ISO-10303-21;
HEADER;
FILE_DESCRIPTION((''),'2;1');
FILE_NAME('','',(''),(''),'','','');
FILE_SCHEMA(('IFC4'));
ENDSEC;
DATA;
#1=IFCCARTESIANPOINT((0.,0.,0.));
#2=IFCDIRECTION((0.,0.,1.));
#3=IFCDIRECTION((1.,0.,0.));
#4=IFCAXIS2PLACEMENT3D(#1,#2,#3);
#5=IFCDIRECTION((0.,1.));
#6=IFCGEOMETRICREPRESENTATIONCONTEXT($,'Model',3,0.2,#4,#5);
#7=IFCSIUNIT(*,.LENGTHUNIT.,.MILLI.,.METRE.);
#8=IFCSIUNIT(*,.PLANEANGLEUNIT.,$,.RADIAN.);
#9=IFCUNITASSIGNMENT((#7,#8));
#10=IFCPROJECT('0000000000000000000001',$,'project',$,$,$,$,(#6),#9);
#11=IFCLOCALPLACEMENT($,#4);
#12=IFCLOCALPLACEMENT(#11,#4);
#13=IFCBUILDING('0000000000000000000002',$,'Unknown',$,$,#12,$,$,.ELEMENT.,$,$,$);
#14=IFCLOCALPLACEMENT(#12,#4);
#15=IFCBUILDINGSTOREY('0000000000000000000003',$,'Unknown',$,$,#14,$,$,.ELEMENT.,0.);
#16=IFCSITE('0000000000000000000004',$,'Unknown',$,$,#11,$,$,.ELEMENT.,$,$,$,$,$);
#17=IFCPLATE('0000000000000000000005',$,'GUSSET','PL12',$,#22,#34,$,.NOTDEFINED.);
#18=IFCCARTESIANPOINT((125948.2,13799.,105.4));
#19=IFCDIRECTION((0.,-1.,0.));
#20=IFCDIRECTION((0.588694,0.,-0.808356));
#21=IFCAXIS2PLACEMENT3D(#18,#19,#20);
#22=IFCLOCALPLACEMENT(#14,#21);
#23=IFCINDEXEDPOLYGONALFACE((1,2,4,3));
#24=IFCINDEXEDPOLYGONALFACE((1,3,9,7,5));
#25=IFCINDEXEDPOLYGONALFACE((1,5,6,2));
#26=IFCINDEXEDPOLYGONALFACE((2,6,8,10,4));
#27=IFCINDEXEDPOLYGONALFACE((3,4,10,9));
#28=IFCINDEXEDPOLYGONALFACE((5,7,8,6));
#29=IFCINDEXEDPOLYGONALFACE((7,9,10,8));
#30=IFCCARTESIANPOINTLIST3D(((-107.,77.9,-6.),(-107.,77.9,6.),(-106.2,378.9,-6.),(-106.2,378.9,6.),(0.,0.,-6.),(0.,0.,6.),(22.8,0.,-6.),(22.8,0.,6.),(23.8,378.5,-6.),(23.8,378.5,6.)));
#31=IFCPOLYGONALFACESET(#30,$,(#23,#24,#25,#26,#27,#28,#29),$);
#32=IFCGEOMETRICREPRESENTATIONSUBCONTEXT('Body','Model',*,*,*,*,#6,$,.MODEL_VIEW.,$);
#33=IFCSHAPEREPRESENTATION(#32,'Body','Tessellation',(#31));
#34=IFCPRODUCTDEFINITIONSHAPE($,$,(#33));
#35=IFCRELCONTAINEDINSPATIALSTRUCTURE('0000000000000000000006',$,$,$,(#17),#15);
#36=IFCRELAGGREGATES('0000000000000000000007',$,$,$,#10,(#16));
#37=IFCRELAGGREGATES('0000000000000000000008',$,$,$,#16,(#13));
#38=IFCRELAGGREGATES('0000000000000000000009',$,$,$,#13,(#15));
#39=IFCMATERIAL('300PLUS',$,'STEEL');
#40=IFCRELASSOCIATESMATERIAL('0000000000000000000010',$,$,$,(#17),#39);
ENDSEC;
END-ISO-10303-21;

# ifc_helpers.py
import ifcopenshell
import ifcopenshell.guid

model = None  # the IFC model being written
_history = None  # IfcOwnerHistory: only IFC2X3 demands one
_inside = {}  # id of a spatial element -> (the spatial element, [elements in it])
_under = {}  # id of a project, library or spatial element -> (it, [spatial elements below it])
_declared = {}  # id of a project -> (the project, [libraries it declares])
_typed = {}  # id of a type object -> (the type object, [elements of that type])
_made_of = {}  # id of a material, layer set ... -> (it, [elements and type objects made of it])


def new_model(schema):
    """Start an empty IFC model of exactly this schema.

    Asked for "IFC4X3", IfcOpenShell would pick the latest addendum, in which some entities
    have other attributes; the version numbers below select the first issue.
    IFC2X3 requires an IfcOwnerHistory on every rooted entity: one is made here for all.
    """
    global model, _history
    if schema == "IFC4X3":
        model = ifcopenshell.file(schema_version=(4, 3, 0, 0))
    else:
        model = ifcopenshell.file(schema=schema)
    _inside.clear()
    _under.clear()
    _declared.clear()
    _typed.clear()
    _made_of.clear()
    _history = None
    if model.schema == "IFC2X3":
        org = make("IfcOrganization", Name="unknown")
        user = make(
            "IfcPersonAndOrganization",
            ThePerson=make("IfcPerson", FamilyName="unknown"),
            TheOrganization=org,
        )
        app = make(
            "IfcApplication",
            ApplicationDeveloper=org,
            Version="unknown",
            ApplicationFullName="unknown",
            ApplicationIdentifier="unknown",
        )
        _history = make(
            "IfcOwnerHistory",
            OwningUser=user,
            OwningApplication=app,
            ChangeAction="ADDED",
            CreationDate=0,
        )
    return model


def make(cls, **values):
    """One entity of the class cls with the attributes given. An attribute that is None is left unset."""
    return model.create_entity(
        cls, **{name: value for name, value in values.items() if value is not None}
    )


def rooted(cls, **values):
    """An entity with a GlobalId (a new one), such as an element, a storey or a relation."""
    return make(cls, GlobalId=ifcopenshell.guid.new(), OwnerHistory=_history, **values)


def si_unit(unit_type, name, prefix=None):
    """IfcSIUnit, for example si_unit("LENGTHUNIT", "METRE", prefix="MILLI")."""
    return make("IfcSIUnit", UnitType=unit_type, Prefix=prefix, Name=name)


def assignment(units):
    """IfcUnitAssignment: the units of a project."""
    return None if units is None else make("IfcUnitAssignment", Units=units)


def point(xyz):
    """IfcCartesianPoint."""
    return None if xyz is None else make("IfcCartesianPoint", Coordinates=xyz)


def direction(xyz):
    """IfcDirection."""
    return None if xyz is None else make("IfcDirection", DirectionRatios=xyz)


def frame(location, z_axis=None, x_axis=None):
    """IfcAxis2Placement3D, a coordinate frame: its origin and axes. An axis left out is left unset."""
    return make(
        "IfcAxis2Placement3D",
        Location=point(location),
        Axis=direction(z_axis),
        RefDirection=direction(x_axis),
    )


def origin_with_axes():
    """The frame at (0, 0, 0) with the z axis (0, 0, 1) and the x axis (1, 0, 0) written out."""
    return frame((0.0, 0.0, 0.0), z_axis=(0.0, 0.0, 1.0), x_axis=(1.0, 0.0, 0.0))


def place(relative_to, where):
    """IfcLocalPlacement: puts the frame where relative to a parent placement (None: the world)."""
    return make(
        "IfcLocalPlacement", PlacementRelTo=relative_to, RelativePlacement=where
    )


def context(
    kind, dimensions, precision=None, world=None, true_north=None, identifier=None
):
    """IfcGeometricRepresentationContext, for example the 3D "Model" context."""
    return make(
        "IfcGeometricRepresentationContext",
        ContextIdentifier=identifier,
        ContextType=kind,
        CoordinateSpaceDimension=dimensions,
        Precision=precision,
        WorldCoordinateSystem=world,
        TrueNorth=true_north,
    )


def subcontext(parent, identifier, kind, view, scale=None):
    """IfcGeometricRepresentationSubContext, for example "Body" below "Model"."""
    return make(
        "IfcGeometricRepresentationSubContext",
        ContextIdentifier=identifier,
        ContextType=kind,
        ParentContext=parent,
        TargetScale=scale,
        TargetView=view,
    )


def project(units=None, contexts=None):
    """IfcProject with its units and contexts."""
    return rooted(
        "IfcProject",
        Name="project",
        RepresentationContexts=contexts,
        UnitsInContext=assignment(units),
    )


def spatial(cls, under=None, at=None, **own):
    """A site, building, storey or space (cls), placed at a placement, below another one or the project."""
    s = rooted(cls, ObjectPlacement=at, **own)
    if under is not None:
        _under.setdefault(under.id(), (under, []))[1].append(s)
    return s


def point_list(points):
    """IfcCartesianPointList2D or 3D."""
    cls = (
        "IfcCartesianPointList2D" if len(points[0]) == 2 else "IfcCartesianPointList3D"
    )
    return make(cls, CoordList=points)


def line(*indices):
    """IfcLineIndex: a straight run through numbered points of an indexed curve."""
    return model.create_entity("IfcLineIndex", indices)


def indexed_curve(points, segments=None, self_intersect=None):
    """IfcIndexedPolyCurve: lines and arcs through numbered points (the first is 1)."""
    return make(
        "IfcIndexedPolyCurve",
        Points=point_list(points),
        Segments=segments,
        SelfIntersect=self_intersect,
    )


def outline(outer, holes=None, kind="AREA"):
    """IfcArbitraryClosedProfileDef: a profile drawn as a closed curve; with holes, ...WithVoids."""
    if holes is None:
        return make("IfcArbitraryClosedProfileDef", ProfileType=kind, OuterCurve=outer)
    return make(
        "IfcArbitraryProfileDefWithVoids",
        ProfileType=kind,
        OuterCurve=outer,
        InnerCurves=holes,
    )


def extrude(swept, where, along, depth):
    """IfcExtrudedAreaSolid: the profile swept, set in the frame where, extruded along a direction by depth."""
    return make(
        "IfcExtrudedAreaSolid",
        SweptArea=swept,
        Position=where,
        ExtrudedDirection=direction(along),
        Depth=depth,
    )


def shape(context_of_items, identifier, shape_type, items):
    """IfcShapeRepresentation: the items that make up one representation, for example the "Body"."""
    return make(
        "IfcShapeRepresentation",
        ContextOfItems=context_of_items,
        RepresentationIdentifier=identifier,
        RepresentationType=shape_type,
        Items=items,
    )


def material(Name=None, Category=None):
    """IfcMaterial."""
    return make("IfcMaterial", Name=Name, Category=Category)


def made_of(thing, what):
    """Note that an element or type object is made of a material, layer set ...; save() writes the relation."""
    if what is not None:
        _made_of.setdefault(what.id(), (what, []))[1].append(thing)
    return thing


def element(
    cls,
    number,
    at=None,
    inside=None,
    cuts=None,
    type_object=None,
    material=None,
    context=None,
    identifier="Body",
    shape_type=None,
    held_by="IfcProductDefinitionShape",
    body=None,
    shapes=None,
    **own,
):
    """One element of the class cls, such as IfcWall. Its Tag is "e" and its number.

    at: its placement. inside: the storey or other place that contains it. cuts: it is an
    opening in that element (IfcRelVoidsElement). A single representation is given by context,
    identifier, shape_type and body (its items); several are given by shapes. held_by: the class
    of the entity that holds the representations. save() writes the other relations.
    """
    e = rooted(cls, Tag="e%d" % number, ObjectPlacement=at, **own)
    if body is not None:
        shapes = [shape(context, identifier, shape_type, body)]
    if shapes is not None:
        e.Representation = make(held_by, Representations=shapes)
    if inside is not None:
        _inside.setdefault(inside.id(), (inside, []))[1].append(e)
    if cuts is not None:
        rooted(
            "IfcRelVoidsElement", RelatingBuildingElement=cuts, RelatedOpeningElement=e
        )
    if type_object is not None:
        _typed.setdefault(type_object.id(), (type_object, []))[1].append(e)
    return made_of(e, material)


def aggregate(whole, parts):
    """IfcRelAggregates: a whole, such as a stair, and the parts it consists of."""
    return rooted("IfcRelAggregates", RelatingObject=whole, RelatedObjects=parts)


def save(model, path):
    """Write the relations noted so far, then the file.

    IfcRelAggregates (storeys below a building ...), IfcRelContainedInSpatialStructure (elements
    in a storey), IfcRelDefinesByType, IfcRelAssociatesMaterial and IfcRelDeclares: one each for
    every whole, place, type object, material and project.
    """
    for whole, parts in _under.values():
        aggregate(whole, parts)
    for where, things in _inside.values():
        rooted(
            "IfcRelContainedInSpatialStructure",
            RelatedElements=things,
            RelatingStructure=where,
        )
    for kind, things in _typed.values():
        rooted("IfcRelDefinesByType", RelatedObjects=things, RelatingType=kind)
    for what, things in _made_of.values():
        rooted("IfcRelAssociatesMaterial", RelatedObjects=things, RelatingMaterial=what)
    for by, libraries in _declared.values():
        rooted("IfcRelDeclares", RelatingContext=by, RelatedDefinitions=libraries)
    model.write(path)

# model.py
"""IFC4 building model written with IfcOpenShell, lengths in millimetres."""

from ifc_helpers import new_model, si_unit, direction, frame, origin_with_axes, place, context, subcontext, project, spatial, line, indexed_curve, outline, extrude, material, element, save


model = new_model("IFC4")

# Units and contexts
model_context = context("Model", 3, precision=0.2, world=origin_with_axes(), true_north=direction((0.0, 1.0)))
body_context = subcontext(model_context, "Body", "Model", "MODEL_VIEW")
ifc_project = project(units=[si_unit("LENGTHUNIT", "METRE", prefix="MILLI"), si_unit("PLANEANGLEUNIT", "RADIAN")], contexts=[model_context])

# Site, building, storey
site_placement = place(None, origin_with_axes())
site = spatial("IfcSite", under=ifc_project, at=site_placement, Name="Unknown", CompositionType="ELEMENT")
building_placement = place(site_placement, origin_with_axes())
building = spatial("IfcBuilding", under=site, at=building_placement, Name="Unknown", CompositionType="ELEMENT")
storey_placement = place(building_placement, origin_with_axes())
storey = spatial("IfcBuildingStorey", under=building, at=storey_placement, Name="Unknown", CompositionType="ELEMENT", Elevation=0.0)

# Shared definitions
ifc_material_1 = material(Name="300PLUS", Category="STEEL")

# Plate
plate_1_placement = place(storey_placement, frame((125948.2, 13799.0, 105.4), z_axis=(0.0, -1.0, 0.0), x_axis=(0.588694, 0.0, -0.808356)))
element("IfcPlate", 1, at=plate_1_placement, inside=storey, material=ifc_material_1, Name="GUSSET", Description="PL12", PredefinedType="NOTDEFINED", context=body_context, shape_type="SolidModel", body=[
    extrude(outline(indexed_curve([(0.0, 0.0), (22.8, 0.0), (23.8, 378.5), (-106.2, 378.9), (-107.0, 77.9)], segments=[line(1, 2, 3, 4, 5, 1)])), frame((0.0, 0.0, 6.0), z_axis=(0.0, 0.0, 1.0), x_axis=(1.0, 0.0, 0.0)), (0.0, 0.0, -1.0), 12.0),
])

save(model, "model.ifc")
